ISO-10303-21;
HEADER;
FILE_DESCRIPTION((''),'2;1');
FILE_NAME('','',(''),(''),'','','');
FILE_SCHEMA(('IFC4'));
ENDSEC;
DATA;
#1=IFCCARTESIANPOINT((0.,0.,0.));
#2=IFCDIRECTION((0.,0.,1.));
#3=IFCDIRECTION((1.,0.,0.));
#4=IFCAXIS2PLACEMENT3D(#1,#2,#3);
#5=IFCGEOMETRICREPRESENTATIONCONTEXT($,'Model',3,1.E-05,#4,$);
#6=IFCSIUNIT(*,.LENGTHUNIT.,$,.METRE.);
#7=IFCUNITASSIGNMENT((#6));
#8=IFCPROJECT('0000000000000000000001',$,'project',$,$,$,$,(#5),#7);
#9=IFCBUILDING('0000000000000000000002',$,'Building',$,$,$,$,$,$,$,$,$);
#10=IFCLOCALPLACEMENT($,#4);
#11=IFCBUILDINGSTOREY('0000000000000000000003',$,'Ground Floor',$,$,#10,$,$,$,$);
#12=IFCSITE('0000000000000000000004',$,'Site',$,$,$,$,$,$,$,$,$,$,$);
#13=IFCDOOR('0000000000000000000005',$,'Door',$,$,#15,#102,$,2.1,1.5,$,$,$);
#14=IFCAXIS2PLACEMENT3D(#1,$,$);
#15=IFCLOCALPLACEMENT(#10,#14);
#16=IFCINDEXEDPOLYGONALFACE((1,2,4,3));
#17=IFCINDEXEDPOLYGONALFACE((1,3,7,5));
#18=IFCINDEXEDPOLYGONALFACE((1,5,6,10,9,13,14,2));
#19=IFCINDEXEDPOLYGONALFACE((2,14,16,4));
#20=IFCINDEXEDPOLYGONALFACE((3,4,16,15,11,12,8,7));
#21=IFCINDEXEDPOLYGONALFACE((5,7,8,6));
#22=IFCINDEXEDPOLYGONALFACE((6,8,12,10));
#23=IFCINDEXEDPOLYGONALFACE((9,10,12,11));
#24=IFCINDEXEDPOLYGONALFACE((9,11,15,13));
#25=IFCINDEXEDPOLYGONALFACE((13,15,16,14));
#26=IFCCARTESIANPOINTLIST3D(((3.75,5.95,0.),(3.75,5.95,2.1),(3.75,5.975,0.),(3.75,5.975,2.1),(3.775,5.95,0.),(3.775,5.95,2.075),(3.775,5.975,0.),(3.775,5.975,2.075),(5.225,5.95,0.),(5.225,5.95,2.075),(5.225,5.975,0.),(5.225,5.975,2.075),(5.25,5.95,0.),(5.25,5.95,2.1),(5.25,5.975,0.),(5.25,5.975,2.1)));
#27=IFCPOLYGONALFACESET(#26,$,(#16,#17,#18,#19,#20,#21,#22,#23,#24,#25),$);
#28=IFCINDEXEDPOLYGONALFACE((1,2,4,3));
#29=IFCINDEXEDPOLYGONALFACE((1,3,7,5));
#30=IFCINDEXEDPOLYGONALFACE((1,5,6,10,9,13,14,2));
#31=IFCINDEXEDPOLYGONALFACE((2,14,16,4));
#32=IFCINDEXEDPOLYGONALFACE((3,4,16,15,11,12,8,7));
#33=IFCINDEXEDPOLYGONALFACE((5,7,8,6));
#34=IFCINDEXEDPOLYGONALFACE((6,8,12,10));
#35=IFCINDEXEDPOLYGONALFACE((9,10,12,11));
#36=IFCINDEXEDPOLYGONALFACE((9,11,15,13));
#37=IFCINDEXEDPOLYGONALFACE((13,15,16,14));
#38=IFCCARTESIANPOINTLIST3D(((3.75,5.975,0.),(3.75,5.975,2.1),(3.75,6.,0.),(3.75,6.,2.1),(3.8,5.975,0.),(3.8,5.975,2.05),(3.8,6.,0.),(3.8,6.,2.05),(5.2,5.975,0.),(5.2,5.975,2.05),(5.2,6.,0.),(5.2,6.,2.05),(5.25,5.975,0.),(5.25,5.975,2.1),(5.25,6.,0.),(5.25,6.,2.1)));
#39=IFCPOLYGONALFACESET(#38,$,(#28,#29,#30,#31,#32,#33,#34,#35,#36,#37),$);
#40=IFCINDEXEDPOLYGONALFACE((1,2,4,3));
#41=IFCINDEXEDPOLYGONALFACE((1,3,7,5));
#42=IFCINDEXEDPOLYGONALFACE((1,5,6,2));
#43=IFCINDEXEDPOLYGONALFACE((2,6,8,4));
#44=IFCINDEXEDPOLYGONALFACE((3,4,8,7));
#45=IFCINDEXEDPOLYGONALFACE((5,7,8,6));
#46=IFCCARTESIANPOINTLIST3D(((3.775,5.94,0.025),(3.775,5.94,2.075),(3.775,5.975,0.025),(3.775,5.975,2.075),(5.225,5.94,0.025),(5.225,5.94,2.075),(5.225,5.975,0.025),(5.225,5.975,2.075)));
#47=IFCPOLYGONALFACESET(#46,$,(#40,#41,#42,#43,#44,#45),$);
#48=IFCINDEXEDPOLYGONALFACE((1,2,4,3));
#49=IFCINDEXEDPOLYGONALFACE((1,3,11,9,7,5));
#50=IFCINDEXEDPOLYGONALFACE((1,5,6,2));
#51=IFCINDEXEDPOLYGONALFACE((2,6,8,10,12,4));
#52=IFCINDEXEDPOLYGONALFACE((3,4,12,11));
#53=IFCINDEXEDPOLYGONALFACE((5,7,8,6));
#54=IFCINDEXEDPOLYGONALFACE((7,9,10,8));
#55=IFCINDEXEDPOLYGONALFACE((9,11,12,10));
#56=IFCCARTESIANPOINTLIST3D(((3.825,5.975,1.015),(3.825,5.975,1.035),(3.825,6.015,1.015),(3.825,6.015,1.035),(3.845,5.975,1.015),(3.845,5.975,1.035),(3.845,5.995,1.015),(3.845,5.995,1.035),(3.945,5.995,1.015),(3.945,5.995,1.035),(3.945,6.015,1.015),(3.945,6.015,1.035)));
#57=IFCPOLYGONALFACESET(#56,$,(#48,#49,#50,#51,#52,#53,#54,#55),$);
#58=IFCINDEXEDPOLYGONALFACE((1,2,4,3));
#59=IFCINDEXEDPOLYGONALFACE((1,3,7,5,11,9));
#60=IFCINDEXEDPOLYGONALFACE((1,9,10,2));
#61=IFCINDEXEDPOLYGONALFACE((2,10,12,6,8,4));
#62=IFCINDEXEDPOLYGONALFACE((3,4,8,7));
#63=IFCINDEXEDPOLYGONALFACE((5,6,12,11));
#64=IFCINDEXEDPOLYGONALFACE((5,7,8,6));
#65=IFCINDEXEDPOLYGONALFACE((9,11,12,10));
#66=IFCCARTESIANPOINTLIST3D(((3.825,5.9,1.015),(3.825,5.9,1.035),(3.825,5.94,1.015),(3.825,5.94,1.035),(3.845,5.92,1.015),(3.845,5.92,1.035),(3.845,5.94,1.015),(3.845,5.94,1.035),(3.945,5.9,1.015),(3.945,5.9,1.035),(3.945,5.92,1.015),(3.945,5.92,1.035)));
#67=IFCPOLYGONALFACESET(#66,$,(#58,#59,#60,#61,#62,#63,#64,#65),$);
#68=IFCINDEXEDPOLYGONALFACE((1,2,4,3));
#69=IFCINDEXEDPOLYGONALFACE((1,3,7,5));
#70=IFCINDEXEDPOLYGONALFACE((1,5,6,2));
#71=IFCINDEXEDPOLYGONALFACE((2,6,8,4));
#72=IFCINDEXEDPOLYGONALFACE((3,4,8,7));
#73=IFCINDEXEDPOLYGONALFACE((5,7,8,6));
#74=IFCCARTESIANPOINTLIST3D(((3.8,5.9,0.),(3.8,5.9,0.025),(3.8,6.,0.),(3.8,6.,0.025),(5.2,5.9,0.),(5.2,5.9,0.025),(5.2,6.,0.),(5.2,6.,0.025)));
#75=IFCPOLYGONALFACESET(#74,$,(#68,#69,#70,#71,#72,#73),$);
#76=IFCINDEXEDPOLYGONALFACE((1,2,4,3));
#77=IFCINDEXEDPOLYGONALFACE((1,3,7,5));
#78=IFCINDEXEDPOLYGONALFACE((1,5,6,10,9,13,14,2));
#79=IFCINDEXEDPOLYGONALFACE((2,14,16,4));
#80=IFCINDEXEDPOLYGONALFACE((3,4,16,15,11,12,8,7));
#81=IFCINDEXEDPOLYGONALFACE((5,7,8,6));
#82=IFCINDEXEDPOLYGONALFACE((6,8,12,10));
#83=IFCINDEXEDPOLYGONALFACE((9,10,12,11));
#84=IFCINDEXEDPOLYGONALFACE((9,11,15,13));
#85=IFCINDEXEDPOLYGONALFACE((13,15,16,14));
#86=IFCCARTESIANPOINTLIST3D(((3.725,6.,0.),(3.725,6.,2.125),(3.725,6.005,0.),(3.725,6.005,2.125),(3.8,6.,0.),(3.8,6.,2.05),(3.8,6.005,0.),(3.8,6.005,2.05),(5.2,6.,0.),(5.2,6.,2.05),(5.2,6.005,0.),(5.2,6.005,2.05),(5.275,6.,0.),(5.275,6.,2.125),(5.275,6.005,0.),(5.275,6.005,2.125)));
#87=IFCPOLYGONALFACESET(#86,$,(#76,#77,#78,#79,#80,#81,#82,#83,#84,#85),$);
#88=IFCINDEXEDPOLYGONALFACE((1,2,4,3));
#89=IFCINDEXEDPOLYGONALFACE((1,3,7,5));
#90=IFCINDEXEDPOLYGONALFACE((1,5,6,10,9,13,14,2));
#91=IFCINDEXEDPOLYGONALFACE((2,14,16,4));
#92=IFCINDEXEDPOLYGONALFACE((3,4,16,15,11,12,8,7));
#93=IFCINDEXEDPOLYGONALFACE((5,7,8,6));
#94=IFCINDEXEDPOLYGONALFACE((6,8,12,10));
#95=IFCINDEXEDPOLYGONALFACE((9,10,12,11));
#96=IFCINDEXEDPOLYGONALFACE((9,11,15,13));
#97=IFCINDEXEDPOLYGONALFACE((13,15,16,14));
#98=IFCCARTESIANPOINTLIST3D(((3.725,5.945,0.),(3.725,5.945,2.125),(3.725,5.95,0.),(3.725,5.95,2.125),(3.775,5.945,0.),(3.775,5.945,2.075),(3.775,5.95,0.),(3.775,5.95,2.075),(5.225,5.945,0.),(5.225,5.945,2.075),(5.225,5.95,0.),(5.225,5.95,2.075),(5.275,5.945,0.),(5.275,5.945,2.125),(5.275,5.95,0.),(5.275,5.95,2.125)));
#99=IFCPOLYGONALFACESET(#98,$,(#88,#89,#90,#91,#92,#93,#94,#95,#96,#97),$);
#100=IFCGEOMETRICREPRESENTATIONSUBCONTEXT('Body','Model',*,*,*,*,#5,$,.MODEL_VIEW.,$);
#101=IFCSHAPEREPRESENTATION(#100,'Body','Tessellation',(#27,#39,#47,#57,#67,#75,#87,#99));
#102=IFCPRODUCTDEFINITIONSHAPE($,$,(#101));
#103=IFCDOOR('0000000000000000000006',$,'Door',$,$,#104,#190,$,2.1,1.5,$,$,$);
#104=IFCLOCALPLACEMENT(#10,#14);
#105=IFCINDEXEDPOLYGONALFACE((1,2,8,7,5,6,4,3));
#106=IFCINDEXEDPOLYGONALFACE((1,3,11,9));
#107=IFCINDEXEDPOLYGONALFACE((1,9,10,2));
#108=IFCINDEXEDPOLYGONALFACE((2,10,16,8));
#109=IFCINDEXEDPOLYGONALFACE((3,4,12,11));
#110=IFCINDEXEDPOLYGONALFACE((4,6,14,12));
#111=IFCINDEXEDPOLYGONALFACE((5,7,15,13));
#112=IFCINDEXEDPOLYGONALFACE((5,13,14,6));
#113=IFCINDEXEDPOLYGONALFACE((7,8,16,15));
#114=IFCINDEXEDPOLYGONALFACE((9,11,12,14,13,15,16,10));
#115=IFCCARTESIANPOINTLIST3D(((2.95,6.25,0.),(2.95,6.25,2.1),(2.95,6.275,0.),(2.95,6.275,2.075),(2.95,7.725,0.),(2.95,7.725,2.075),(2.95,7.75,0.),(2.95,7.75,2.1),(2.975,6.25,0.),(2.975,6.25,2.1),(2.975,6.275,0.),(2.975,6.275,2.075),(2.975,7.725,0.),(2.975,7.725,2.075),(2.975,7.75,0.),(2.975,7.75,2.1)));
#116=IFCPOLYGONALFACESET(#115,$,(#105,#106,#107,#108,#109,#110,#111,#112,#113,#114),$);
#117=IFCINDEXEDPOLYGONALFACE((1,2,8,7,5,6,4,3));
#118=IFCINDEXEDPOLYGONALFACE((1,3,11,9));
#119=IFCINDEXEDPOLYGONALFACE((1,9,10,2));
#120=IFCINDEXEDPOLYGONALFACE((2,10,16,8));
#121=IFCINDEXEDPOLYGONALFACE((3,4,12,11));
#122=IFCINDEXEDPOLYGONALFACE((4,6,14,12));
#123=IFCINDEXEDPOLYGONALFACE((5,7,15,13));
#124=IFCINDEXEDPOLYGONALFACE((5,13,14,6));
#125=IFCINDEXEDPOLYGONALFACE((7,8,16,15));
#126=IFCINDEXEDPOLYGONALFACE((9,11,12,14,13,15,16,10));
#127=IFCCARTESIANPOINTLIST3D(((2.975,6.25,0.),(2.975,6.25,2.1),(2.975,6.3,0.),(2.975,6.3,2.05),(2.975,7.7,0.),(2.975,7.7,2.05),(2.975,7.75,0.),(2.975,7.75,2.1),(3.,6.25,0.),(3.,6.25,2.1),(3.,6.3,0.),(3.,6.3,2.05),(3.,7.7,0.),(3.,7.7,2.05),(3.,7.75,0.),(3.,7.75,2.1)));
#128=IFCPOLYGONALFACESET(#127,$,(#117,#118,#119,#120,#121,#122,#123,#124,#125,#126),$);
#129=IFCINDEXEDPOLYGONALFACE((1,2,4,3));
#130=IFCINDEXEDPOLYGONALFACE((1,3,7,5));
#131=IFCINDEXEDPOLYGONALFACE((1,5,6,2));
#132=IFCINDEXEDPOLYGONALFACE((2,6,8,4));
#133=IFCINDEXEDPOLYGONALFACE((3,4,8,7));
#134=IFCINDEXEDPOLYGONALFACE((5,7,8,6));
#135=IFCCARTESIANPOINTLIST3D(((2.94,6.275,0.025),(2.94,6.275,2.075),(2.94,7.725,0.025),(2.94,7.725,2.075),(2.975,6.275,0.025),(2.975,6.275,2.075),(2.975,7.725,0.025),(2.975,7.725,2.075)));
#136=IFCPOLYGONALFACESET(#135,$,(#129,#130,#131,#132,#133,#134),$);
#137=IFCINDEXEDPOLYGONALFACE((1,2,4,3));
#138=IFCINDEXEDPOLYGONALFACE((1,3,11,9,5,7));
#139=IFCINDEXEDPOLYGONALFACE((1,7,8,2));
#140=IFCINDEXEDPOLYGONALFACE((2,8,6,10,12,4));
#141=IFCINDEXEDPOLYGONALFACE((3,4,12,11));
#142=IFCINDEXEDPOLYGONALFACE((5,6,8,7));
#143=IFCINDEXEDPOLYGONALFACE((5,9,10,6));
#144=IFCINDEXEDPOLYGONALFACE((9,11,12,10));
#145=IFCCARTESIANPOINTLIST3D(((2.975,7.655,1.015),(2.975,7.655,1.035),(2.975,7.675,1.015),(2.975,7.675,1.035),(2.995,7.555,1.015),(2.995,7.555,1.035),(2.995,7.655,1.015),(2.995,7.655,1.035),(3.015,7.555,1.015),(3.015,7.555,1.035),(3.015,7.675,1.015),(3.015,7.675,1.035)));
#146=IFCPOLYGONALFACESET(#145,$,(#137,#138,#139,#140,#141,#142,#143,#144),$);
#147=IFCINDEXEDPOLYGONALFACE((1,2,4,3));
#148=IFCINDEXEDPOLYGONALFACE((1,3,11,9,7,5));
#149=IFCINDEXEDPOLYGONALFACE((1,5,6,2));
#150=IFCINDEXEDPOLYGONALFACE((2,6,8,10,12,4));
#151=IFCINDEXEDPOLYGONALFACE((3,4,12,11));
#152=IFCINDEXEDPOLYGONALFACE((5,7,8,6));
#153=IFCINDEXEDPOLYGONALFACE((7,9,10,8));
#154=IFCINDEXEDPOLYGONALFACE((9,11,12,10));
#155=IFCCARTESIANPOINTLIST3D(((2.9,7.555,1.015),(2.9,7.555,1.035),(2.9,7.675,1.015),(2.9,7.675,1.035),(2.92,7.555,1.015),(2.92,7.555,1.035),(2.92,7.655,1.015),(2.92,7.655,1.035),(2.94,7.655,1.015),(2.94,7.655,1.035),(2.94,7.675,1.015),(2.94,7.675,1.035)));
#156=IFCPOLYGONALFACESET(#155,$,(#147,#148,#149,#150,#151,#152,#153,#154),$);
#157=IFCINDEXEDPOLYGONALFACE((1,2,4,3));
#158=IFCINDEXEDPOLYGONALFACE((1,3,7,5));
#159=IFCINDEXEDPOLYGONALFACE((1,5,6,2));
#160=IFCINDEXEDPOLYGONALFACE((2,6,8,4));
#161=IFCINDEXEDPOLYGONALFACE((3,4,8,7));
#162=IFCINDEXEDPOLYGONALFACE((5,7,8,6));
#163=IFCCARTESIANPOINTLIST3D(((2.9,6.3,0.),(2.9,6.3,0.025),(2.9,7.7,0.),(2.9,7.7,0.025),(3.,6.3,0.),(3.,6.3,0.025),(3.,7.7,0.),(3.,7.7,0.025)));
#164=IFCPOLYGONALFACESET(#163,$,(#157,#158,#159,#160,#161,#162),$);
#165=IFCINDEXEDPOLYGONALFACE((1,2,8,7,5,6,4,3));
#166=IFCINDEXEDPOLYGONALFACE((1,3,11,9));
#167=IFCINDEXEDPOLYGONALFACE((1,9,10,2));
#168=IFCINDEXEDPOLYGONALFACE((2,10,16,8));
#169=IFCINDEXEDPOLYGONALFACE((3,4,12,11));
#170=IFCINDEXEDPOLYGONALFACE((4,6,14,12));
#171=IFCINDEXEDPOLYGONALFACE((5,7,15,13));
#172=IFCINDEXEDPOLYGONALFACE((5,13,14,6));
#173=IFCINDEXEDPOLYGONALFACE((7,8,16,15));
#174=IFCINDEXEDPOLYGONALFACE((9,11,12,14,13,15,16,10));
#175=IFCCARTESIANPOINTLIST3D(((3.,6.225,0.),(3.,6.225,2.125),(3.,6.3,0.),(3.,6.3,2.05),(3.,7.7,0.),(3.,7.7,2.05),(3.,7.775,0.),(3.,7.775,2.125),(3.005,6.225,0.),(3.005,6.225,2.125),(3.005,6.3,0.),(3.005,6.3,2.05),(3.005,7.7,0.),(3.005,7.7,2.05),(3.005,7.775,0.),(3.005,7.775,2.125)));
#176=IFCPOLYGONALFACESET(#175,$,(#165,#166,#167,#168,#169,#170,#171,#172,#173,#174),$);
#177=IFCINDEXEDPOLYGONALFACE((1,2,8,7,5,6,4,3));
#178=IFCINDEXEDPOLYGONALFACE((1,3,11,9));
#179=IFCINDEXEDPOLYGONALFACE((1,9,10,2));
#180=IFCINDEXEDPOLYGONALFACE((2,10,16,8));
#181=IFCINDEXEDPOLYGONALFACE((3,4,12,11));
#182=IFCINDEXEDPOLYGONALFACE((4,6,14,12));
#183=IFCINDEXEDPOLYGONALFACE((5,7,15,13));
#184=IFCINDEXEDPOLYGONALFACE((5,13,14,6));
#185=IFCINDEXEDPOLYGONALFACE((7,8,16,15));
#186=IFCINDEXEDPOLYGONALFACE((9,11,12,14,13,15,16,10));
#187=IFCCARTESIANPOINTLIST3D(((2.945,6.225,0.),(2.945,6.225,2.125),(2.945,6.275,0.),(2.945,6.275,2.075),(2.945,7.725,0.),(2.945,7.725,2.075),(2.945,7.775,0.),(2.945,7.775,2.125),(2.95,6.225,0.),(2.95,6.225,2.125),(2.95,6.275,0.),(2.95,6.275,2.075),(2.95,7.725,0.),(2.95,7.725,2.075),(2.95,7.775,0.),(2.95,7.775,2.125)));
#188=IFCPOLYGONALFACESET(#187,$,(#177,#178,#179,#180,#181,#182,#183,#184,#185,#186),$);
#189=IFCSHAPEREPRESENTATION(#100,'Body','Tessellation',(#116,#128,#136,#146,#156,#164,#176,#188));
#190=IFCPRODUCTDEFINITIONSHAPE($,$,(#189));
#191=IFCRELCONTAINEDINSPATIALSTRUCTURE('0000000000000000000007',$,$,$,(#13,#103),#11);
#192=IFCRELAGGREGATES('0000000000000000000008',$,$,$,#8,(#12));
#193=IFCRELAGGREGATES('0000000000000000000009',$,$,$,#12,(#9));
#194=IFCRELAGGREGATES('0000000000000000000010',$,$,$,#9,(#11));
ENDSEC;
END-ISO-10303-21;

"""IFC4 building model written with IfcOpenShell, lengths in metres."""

from ifc_helpers import new_model, si_unit, frame, origin_with_axes, place, context, subcontext, project, spatial, line, indexed_curve, outline, extrude, element, save


model = new_model("IFC4")

# Units and contexts
model_context = context("Model", 3, precision=1e-05, world=origin_with_axes())
body_context = subcontext(model_context, "Body", "Model", "MODEL_VIEW")
ifc_project = project(units=[si_unit("LENGTHUNIT", "METRE")], contexts=[model_context])

# Site, building, storey
site = spatial("IfcSite", under=ifc_project, Name="Site")
building = spatial("IfcBuilding", under=site, Name="Building")
storey_placement = place(None, origin_with_axes())
storey = spatial("IfcBuildingStorey", under=building, at=storey_placement, Name="Ground Floor")

# Doors
door_1_placement = place(storey_placement, frame((5.25, 6.0, 0.0), z_axis=(0.0, 0.0, 1.0), x_axis=(-1.0, 0.0, 0.0)))
element("IfcDoor", 1, at=door_1_placement, inside=storey, Name="Door", OverallHeight=2.1, OverallWidth=1.5, context=body_context, shape_type="SweptSolid", body=[
    extrude(outline(indexed_curve([(0.0, 0.0), (0.0, 2.1), (1.5, 2.1), (1.5, 0.0), (1.475, 0.0), (1.475, 2.075), (0.025, 2.075), (0.025, 0.0)], segments=[line(1, 2, 3, 4, 5, 6, 7, 8, 1)])), frame((0.0, 0.025, 0.0), z_axis=(0.0, -1.0, 0.0), x_axis=(1.0, 0.0, 0.0)), (0.0, 0.0, -1.0), 0.025),
    extrude(outline(indexed_curve([(0.0, 0.0), (0.0, 2.1), (1.5, 2.1), (1.5, 0.0), (1.45, 0.0), (1.45, 2.05), (0.05, 2.05), (0.05, 0.0)], segments=[line(1, 2, 3, 4, 5, 6, 7, 8, 1)])), frame((0.0, 0.0, 0.0), z_axis=(0.0, -1.0, 0.0), x_axis=(1.0, 0.0, 0.0)), (0.0, 0.0, -1.0), 0.025),
    extrude(outline(indexed_curve([(0.0, 0.0), (1.45, 0.0), (1.45, 0.035), (0.0, 0.035)], segments=[line(1, 2, 3, 4, 1)])), frame((0.025, 0.025, 0.025), z_axis=(0.0, 0.0, 1.0), x_axis=(1.0, 0.0, 0.0)), (0.0, 0.0, 1.0), 2.05),
    extrude(outline(indexed_curve([(0.0, 0.0), (0.0, -0.04), (-0.12, -0.04), (-0.12, -0.02), (-0.02, -0.02), (-0.02, 0.0)], segments=[line(1, 2, 3, 4, 5, 6, 1)])), frame((1.425, 0.025, 1.015), z_axis=(0.0, 0.0, 1.0), x_axis=(1.0, 0.0, 0.0)), (0.0, 0.0, 1.0), 0.02),
    extrude(outline(indexed_curve([(0.0, 0.0), (0.0, 0.04), (-0.12, 0.04), (-0.12, 0.02), (-0.02, 0.02), (-0.02, 0.0)], segments=[line(1, 2, 3, 4, 5, 6, 1)])), frame((1.425, 0.06, 1.015), z_axis=(0.0, 0.0, 1.0), x_axis=(1.0, 0.0, 0.0)), (0.0, 0.0, 1.0), 0.02),
    extrude(outline(indexed_curve([(0.0, 0.0), (1.4, 0.0), (1.4, 0.1), (0.0, 0.1)], segments=[line(1, 2, 3, 4, 1)])), frame((0.05, 0.0, 0.0), z_axis=(0.0, 0.0, 1.0), x_axis=(1.0, 0.0, 0.0)), (0.0, 0.0, 1.0), 0.025),
    extrude(outline(indexed_curve([(0.0, 0.0), (0.0, 2.125), (1.55, 2.125), (1.55, 0.0), (1.475, 0.0), (1.475, 2.05), (0.075, 2.05), (0.075, 0.0)], segments=[line(1, 2, 3, 4, 5, 6, 7, 8, 1)])), frame((-0.025, -0.005, 0.0), z_axis=(0.0, -1.0, 0.0), x_axis=(1.0, 0.0, 0.0)), (0.0, 0.0, -1.0), 0.005),
    extrude(outline(indexed_curve([(0.0, 0.0), (0.0, 2.125), (1.55, 2.125), (1.55, 0.0), (1.5, 0.0), (1.5, 2.075), (0.05, 2.075), (0.05, 0.0)], segments=[line(1, 2, 3, 4, 5, 6, 7, 8, 1)])), frame((-0.025, 0.05, 0.0), z_axis=(0.0, -1.0, 0.0), x_axis=(1.0, 0.0, 0.0)), (0.0, 0.0, -1.0), 0.005),
])
door_2_placement = place(storey_placement, frame((3.0, 6.25, 0.0), z_axis=(0.0, 0.0, 1.0), x_axis=(0.0, 1.0, 0.0)))
element("IfcDoor", 2, at=door_2_placement, inside=storey, Name="Door", OverallHeight=2.1, OverallWidth=1.5, context=body_context, shape_type="SweptSolid", body=[
    extrude(outline(indexed_curve([(0.0, 0.0), (0.0, 2.1), (1.5, 2.1), (1.5, 0.0), (1.475, 0.0), (1.475, 2.075), (0.025, 2.075), (0.025, 0.0)], segments=[line(1, 2, 3, 4, 5, 6, 7, 8, 1)])), frame((0.0, 0.025, 0.0), z_axis=(0.0, -1.0, 0.0), x_axis=(1.0, 0.0, 0.0)), (0.0, 0.0, -1.0), 0.025),
    extrude(outline(indexed_curve([(0.0, 0.0), (0.0, 2.1), (1.5, 2.1), (1.5, 0.0), (1.45, 0.0), (1.45, 2.05), (0.05, 2.05), (0.05, 0.0)], segments=[line(1, 2, 3, 4, 5, 6, 7, 8, 1)])), frame((0.0, 0.0, 0.0), z_axis=(0.0, -1.0, 0.0), x_axis=(1.0, 0.0, 0.0)), (0.0, 0.0, -1.0), 0.025),
    extrude(outline(indexed_curve([(0.0, 0.0), (1.45, 0.0), (1.45, 0.035), (0.0, 0.035)], segments=[line(1, 2, 3, 4, 1)])), frame((0.025, 0.025, 0.025), z_axis=(0.0, 0.0, 1.0), x_axis=(1.0, 0.0, 0.0)), (0.0, 0.0, 1.0), 2.05),
    extrude(outline(indexed_curve([(0.0, 0.0), (0.0, -0.04), (-0.12, -0.04), (-0.12, -0.02), (-0.02, -0.02), (-0.02, 0.0)], segments=[line(1, 2, 3, 4, 5, 6, 1)])), frame((1.425, 0.025, 1.015), z_axis=(0.0, 0.0, 1.0), x_axis=(1.0, 0.0, 0.0)), (0.0, 0.0, 1.0), 0.02),
    extrude(outline(indexed_curve([(0.0, 0.0), (0.0, 0.04), (-0.12, 0.04), (-0.12, 0.02), (-0.02, 0.02), (-0.02, 0.0)], segments=[line(1, 2, 3, 4, 5, 6, 1)])), frame((1.425, 0.06, 1.015), z_axis=(0.0, 0.0, 1.0), x_axis=(1.0, 0.0, 0.0)), (0.0, 0.0, 1.0), 0.02),
    extrude(outline(indexed_curve([(0.0, 0.0), (1.4, 0.0), (1.4, 0.1), (0.0, 0.1)], segments=[line(1, 2, 3, 4, 1)])), frame((0.05, 0.0, 0.0), z_axis=(0.0, 0.0, 1.0), x_axis=(1.0, 0.0, 0.0)), (0.0, 0.0, 1.0), 0.025),
    extrude(outline(indexed_curve([(0.0, 0.0), (0.0, 2.125), (1.55, 2.125), (1.55, 0.0), (1.475, 0.0), (1.475, 2.05), (0.075, 2.05), (0.075, 0.0)], segments=[line(1, 2, 3, 4, 5, 6, 7, 8, 1)])), frame((-0.025, -0.005, 0.0), z_axis=(0.0, -1.0, 0.0), x_axis=(1.0, 0.0, 0.0)), (0.0, 0.0, -1.0), 0.005),
    extrude(outline(indexed_curve([(0.0, 0.0), (0.0, 2.125), (1.55, 2.125), (1.55, 0.0), (1.5, 0.0), (1.5, 2.075), (0.05, 2.075), (0.05, 0.0)], segments=[line(1, 2, 3, 4, 5, 6, 7, 8, 1)])), frame((-0.025, 0.05, 0.0), z_axis=(0.0, -1.0, 0.0), x_axis=(1.0, 0.0, 0.0)), (0.0, 0.0, -1.0), 0.005),
])

save(model, "model.ifc")
